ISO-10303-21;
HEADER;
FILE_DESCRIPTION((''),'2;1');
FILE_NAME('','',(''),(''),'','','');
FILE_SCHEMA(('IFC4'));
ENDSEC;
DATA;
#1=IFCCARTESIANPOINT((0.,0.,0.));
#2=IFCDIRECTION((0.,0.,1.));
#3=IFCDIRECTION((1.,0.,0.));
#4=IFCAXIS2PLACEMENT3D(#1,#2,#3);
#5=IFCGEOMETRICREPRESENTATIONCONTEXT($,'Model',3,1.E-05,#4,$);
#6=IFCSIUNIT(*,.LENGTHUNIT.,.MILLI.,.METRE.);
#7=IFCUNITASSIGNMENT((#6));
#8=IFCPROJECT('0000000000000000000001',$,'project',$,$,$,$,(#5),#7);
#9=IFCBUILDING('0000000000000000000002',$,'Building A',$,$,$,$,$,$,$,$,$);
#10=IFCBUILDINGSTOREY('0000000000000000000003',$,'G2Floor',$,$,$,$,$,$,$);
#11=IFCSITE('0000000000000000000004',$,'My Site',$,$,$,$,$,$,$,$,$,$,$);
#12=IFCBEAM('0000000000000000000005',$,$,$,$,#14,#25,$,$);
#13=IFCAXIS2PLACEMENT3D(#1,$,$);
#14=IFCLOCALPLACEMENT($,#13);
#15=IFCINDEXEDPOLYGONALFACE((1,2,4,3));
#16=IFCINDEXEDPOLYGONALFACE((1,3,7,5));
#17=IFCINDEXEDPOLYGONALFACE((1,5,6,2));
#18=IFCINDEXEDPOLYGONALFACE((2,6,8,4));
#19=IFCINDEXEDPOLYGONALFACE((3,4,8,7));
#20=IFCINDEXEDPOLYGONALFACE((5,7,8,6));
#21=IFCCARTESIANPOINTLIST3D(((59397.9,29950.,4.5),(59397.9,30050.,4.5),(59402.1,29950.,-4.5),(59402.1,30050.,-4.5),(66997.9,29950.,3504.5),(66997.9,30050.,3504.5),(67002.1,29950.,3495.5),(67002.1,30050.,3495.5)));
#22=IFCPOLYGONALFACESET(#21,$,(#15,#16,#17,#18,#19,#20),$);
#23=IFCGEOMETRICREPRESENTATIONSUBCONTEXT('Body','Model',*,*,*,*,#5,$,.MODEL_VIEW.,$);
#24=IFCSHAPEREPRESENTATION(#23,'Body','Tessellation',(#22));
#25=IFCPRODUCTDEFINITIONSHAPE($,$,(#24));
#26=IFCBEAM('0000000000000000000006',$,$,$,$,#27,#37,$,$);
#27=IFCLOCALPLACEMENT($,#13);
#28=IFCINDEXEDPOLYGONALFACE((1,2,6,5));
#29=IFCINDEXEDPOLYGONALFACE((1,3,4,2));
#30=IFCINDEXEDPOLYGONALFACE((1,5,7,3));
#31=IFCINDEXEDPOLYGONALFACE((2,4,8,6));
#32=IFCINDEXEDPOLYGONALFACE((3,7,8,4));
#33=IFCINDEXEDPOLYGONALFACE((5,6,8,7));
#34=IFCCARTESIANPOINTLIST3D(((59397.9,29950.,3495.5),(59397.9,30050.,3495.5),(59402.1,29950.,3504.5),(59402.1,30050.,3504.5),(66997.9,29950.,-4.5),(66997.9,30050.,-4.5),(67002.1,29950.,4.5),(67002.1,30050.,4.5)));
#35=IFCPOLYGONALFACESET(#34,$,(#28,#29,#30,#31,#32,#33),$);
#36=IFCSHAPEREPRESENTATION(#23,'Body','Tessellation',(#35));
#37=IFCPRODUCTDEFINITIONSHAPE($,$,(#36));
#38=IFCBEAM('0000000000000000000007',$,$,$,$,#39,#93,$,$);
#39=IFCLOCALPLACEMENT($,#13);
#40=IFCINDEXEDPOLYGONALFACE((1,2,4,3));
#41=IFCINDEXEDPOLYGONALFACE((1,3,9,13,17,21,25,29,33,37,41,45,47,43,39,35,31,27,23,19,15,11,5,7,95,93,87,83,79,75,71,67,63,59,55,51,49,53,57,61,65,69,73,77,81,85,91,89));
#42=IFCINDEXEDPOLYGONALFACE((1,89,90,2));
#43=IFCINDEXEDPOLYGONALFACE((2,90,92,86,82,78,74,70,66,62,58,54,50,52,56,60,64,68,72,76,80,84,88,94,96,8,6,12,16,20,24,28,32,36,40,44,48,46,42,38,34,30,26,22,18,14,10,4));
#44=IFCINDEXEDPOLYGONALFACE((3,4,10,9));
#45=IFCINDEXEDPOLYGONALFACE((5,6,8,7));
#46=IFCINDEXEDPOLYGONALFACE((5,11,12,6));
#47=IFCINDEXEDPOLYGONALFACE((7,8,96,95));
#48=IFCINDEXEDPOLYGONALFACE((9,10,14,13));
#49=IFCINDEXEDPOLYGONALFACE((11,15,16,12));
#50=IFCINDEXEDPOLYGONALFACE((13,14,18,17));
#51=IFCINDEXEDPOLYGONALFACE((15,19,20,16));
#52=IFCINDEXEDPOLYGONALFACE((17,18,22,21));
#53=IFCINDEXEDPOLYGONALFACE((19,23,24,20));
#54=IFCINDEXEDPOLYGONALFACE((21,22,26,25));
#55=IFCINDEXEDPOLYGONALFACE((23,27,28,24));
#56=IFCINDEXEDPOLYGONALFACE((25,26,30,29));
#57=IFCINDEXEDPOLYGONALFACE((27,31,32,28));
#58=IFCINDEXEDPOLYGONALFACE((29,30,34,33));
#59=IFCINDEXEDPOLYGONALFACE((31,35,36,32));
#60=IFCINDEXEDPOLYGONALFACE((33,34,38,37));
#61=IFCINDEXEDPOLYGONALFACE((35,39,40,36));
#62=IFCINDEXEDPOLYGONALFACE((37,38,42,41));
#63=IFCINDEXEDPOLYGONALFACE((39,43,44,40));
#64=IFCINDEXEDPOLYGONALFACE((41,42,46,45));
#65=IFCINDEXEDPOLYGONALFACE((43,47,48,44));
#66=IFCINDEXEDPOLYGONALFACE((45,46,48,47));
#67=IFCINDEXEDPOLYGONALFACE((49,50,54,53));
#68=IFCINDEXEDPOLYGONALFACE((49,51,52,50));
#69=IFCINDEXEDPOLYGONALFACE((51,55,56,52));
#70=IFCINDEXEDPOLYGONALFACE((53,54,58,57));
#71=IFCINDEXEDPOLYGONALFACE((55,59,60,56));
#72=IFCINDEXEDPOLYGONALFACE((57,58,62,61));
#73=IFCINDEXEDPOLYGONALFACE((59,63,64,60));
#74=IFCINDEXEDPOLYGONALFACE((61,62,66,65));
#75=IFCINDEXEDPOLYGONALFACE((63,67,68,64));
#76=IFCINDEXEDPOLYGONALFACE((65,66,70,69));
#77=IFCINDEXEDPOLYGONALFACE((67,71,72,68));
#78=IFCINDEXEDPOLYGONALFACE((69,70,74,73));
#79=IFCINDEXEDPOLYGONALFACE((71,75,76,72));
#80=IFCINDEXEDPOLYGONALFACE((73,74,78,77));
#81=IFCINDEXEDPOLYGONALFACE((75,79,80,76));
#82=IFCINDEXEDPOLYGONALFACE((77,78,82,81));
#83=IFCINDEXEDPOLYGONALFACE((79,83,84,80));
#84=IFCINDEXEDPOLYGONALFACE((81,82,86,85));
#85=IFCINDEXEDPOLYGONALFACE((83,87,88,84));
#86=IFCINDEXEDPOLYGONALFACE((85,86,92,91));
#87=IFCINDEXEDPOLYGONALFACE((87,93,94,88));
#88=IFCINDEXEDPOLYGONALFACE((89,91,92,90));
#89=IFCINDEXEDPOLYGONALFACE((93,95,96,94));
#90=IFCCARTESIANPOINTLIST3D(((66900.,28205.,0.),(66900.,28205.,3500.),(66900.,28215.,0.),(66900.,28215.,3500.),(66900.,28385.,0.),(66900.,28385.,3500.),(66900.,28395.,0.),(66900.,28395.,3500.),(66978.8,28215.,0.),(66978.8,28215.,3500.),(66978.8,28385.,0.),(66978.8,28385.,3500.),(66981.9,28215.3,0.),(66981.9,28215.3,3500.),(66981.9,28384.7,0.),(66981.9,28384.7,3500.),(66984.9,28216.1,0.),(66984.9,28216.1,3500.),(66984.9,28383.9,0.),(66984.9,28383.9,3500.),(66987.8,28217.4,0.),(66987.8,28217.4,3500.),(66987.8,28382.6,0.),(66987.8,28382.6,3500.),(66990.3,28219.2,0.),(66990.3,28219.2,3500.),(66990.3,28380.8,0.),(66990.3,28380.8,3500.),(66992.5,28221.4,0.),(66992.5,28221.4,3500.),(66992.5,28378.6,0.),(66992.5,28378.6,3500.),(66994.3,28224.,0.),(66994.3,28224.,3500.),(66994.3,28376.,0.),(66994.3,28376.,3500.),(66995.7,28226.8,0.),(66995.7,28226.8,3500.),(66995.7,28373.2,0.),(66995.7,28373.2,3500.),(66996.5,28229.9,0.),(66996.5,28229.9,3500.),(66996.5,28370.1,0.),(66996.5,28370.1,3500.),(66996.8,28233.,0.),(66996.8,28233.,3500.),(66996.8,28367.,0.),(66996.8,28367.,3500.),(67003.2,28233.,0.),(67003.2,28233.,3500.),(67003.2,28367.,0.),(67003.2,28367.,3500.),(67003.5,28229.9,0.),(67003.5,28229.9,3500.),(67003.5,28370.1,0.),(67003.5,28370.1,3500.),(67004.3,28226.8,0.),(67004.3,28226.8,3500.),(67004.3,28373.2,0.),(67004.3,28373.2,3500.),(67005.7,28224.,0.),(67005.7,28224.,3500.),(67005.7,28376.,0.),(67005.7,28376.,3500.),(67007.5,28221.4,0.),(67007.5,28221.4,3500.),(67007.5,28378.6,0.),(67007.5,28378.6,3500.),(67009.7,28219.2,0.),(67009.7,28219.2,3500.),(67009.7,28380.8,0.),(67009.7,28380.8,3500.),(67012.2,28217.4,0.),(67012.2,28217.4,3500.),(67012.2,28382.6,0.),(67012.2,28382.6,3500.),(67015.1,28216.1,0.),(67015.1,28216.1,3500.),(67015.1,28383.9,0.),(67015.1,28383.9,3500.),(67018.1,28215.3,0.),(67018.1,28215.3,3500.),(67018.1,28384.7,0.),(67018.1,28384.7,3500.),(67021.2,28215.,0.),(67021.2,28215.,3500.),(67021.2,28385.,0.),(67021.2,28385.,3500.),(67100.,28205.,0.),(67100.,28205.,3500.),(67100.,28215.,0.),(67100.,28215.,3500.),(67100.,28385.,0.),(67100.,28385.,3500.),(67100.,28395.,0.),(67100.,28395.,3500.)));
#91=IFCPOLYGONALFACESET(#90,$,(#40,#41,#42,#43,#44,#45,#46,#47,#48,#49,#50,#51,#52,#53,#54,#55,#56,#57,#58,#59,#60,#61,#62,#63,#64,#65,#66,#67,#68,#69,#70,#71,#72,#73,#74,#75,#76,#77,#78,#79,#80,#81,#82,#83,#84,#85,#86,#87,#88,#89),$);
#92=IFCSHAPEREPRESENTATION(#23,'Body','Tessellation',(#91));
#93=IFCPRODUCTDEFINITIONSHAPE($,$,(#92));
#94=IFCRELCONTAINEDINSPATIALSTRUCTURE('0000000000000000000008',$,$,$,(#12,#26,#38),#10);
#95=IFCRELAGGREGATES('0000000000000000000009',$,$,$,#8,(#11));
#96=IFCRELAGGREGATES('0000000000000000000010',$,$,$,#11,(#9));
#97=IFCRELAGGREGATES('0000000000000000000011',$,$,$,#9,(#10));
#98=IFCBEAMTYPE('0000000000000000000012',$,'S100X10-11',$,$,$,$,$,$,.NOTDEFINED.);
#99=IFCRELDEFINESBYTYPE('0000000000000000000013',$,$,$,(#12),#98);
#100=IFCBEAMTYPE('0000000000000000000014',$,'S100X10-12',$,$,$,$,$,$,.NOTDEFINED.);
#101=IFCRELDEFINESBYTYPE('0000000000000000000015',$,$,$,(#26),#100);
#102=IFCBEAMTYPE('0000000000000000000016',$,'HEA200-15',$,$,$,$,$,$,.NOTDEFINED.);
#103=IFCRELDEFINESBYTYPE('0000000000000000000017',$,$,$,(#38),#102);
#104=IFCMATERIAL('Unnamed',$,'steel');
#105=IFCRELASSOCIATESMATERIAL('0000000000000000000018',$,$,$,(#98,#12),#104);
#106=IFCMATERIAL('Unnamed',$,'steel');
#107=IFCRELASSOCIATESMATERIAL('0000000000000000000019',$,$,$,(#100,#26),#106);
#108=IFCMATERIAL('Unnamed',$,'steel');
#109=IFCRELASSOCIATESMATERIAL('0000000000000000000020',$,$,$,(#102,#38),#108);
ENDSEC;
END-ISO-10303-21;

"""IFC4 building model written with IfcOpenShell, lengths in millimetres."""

from ifc_helpers import new_model, si_unit, frame, origin_with_axes, place, context, subcontext, project, spatial, polyline, outline, extrude, material, material_profile, profile_set, profile_usage, type_object, element, save


model = new_model("IFC4")

# Units and contexts
model_context = context("Model", 3, precision=1e-05, world=origin_with_axes())
body_context = subcontext(model_context, "Body", "Model", "MODEL_VIEW")
ifc_project = project(units=[si_unit("LENGTHUNIT", "METRE", prefix="MILLI")], contexts=[model_context])

# Site, building, storey
site = spatial("IfcSite", under=ifc_project, Name="My Site")
building = spatial("IfcBuilding", under=site, Name="Building A")
storey = spatial("IfcBuildingStorey", under=building, Name="G2Floor")

# Beams
ifc_material_1 = material(Name="Unnamed", Category="steel")
ifc_material_profile_1 = material_profile(ifc_material_1, outline(polyline([(50.0, -5.0), (50.0, 5.0), (50.0, 5.0), (-50.0, 5.0), (-50.0, 5.0), (-50.0, -5.0), (-50.0, -5.0), (50.0, -5.0)])))
ifc_profile_set_1 = profile_set([ifc_material_profile_1], Name="S100X10-11")
ifc_profile_usage_1 = profile_usage(ifc_profile_set_1)
beam_type_1 = type_object("IfcBeamType", Name="S100X10-11", PredefinedType="NOTDEFINED", material=ifc_profile_set_1)
beam_1_placement = place(None, frame((59400.0, 30000.0, 0.0), z_axis=(0.908309, 0.0, 0.4183), x_axis=(0.0, -1.0, 0.0)))
element("IfcBeam", 1, at=beam_1_placement, inside=storey, type_object=beam_type_1, material=ifc_profile_usage_1, context=body_context, shape_type="SweptSolid", body=[
    extrude(outline(polyline([(50.0, -5.0), (50.0, 5.0), (50.0, 5.0), (-50.0, 5.0), (-50.0, 5.0), (-50.0, -5.0), (-50.0, -5.0), (50.0, -5.0)])), origin_with_axes(), (0.0, 0.0, 1.0), 8367.2),
])
ifc_material_2 = material(Name="Unnamed", Category="steel")
ifc_material_profile_2 = material_profile(ifc_material_2, outline(polyline([(50.0, -5.0), (50.0, 5.0), (50.0, 5.0), (-50.0, 5.0), (-50.0, 5.0), (-50.0, -5.0), (-50.0, -5.0), (50.0, -5.0)])))
ifc_profile_set_2 = profile_set([ifc_material_profile_2], Name="S100X10-12")
ifc_profile_usage_2 = profile_usage(ifc_profile_set_2)
beam_type_2 = type_object("IfcBeamType", Name="S100X10-12", PredefinedType="NOTDEFINED", material=ifc_profile_set_2)
beam_2_placement = place(None, frame((59400.0, 30000.0, 3500.0), z_axis=(0.908309, 0.0, -0.4183), x_axis=(0.0, -1.0, 0.0)))
element("IfcBeam", 2, at=beam_2_placement, inside=storey, type_object=beam_type_2, material=ifc_profile_usage_2, context=body_context, shape_type="SweptSolid", body=[
    extrude(outline(polyline([(50.0, -5.0), (50.0, 5.0), (50.0, 5.0), (-50.0, 5.0), (-50.0, 5.0), (-50.0, -5.0), (-50.0, -5.0), (50.0, -5.0)])), origin_with_axes(), (0.0, 0.0, 1.0), 8367.2),
])
ifc_material_3 = material(Name="Unnamed", Category="steel")
ifc_material_profile_3 = material_profile(ifc_material_3, outline(polyline([(100.0, -95.0), (100.0, -85.0), (100.0, -85.0), (21.2, -85.0), (21.2, -85.0), (18.1, -84.7), (18.1, -84.7), (15.1, -83.9), (15.1, -83.9), (12.2, -82.6), (12.2, -82.6), (9.7, -80.8), (9.7, -80.8), (7.5, -78.6), (7.5, -78.6), (5.7, -76.0), (5.7, -76.0), (4.3, -73.2), (4.3, -73.2), (3.5, -70.1), (3.5, -70.1), (3.2, -67.0), (3.2, -67.0), (3.2, 67.0), (3.2, 67.0), (3.5, 70.1), (3.5, 70.1), (4.3, 73.2), (4.3, 73.2), (5.7, 76.0), (5.7, 76.0), (7.5, 78.6), (7.5, 78.6), (9.7, 80.8), (9.7, 80.8), (12.2, 82.6), (12.2, 82.6), (15.1, 83.9), (15.1, 83.9), (18.1, 84.7), (18.1, 84.7), (21.2, 85.0), (21.2, 85.0), (100.0, 85.0), (100.0, 85.0), (100.0, 95.0), (100.0, 95.0), (-100.0, 95.0), (-100.0, 95.0), (-100.0, 85.0), (-100.0, 85.0), (-21.2, 85.0), (-21.2, 85.0), (-18.1, 84.7), (-18.1, 84.7), (-15.1, 83.9), (-15.1, 83.9), (-12.2, 82.6), (-12.2, 82.6), (-9.7, 80.8), (-9.7, 80.8), (-7.5, 78.6), (-7.5, 78.6), (-5.7, 76.0), (-5.7, 76.0), (-4.3, 73.2), (-4.3, 73.2), (-3.5, 70.1), (-3.5, 70.1), (-3.2, 67.0), (-3.2, 67.0), (-3.2, -67.0), (-3.2, -67.0), (-3.5, -70.1), (-3.5, -70.1), (-4.3, -73.2), (-4.3, -73.2), (-5.7, -76.0), (-5.7, -76.0), (-7.5, -78.6), (-7.5, -78.6), (-9.7, -80.8), (-9.7, -80.8), (-12.2, -82.6), (-12.2, -82.6), (-15.1, -83.9), (-15.1, -83.9), (-18.1, -84.7), (-18.1, -84.7), (-21.2, -85.0), (-21.2, -85.0), (-100.0, -85.0), (-100.0, -85.0), (-100.0, -95.0), (-100.0, -95.0), (100.0, -95.0)])))
ifc_profile_set_3 = profile_set([ifc_material_profile_3], Name="HEA200-15")
ifc_profile_usage_3 = profile_usage(ifc_profile_set_3)
beam_type_3 = type_object("IfcBeamType", Name="HEA200-15", PredefinedType="NOTDEFINED", material=ifc_profile_set_3)
beam_3_placement = place(None, frame((67000.0, 28300.0, 0.0), z_axis=(0.0, 0.0, 1.0), x_axis=(1.0, 0.0, 0.0)))
element("IfcBeam", 3, at=beam_3_placement, inside=storey, type_object=beam_type_3, material=ifc_profile_usage_3, context=body_context, shape_type="SweptSolid", body=[
    extrude(outline(polyline([(100.0, -95.0), (100.0, -85.0), (100.0, -85.0), (21.2, -85.0), (21.2, -85.0), (18.1, -84.7), (18.1, -84.7), (15.1, -83.9), (15.1, -83.9), (12.2, -82.6), (12.2, -82.6), (9.7, -80.8), (9.7, -80.8), (7.5, -78.6), (7.5, -78.6), (5.7, -76.0), (5.7, -76.0), (4.3, -73.2), (4.3, -73.2), (3.5, -70.1), (3.5, -70.1), (3.2, -67.0), (3.2, -67.0), (3.2, 67.0), (3.2, 67.0), (3.5, 70.1), (3.5, 70.1), (4.3, 73.2), (4.3, 73.2), (5.7, 76.0), (5.7, 76.0), (7.5, 78.6), (7.5, 78.6), (9.7, 80.8), (9.7, 80.8), (12.2, 82.6), (12.2, 82.6), (15.1, 83.9), (15.1, 83.9), (18.1, 84.7), (18.1, 84.7), (21.2, 85.0), (21.2, 85.0), (100.0, 85.0), (100.0, 85.0), (100.0, 95.0), (100.0, 95.0), (-100.0, 95.0), (-100.0, 95.0), (-100.0, 85.0), (-100.0, 85.0), (-21.2, 85.0), (-21.2, 85.0), (-18.1, 84.7), (-18.1, 84.7), (-15.1, 83.9), (-15.1, 83.9), (-12.2, 82.6), (-12.2, 82.6), (-9.7, 80.8), (-9.7, 80.8), (-7.5, 78.6), (-7.5, 78.6), (-5.7, 76.0), (-5.7, 76.0), (-4.3, 73.2), (-4.3, 73.2), (-3.5, 70.1), (-3.5, 70.1), (-3.2, 67.0), (-3.2, 67.0), (-3.2, -67.0), (-3.2, -67.0), (-3.5, -70.1), (-3.5, -70.1), (-4.3, -73.2), (-4.3, -73.2), (-5.7, -76.0), (-5.7, -76.0), (-7.5, -78.6), (-7.5, -78.6), (-9.7, -80.8), (-9.7, -80.8), (-12.2, -82.6), (-12.2, -82.6), (-15.1, -83.9), (-15.1, -83.9), (-18.1, -84.7), (-18.1, -84.7), (-21.2, -85.0), (-21.2, -85.0), (-100.0, -85.0), (-100.0, -85.0), (-100.0, -95.0), (-100.0, -95.0), (100.0, -95.0)])), origin_with_axes(), (0.0, 0.0, 1.0), 3500.0),
])

save(model, "model.ifc")
